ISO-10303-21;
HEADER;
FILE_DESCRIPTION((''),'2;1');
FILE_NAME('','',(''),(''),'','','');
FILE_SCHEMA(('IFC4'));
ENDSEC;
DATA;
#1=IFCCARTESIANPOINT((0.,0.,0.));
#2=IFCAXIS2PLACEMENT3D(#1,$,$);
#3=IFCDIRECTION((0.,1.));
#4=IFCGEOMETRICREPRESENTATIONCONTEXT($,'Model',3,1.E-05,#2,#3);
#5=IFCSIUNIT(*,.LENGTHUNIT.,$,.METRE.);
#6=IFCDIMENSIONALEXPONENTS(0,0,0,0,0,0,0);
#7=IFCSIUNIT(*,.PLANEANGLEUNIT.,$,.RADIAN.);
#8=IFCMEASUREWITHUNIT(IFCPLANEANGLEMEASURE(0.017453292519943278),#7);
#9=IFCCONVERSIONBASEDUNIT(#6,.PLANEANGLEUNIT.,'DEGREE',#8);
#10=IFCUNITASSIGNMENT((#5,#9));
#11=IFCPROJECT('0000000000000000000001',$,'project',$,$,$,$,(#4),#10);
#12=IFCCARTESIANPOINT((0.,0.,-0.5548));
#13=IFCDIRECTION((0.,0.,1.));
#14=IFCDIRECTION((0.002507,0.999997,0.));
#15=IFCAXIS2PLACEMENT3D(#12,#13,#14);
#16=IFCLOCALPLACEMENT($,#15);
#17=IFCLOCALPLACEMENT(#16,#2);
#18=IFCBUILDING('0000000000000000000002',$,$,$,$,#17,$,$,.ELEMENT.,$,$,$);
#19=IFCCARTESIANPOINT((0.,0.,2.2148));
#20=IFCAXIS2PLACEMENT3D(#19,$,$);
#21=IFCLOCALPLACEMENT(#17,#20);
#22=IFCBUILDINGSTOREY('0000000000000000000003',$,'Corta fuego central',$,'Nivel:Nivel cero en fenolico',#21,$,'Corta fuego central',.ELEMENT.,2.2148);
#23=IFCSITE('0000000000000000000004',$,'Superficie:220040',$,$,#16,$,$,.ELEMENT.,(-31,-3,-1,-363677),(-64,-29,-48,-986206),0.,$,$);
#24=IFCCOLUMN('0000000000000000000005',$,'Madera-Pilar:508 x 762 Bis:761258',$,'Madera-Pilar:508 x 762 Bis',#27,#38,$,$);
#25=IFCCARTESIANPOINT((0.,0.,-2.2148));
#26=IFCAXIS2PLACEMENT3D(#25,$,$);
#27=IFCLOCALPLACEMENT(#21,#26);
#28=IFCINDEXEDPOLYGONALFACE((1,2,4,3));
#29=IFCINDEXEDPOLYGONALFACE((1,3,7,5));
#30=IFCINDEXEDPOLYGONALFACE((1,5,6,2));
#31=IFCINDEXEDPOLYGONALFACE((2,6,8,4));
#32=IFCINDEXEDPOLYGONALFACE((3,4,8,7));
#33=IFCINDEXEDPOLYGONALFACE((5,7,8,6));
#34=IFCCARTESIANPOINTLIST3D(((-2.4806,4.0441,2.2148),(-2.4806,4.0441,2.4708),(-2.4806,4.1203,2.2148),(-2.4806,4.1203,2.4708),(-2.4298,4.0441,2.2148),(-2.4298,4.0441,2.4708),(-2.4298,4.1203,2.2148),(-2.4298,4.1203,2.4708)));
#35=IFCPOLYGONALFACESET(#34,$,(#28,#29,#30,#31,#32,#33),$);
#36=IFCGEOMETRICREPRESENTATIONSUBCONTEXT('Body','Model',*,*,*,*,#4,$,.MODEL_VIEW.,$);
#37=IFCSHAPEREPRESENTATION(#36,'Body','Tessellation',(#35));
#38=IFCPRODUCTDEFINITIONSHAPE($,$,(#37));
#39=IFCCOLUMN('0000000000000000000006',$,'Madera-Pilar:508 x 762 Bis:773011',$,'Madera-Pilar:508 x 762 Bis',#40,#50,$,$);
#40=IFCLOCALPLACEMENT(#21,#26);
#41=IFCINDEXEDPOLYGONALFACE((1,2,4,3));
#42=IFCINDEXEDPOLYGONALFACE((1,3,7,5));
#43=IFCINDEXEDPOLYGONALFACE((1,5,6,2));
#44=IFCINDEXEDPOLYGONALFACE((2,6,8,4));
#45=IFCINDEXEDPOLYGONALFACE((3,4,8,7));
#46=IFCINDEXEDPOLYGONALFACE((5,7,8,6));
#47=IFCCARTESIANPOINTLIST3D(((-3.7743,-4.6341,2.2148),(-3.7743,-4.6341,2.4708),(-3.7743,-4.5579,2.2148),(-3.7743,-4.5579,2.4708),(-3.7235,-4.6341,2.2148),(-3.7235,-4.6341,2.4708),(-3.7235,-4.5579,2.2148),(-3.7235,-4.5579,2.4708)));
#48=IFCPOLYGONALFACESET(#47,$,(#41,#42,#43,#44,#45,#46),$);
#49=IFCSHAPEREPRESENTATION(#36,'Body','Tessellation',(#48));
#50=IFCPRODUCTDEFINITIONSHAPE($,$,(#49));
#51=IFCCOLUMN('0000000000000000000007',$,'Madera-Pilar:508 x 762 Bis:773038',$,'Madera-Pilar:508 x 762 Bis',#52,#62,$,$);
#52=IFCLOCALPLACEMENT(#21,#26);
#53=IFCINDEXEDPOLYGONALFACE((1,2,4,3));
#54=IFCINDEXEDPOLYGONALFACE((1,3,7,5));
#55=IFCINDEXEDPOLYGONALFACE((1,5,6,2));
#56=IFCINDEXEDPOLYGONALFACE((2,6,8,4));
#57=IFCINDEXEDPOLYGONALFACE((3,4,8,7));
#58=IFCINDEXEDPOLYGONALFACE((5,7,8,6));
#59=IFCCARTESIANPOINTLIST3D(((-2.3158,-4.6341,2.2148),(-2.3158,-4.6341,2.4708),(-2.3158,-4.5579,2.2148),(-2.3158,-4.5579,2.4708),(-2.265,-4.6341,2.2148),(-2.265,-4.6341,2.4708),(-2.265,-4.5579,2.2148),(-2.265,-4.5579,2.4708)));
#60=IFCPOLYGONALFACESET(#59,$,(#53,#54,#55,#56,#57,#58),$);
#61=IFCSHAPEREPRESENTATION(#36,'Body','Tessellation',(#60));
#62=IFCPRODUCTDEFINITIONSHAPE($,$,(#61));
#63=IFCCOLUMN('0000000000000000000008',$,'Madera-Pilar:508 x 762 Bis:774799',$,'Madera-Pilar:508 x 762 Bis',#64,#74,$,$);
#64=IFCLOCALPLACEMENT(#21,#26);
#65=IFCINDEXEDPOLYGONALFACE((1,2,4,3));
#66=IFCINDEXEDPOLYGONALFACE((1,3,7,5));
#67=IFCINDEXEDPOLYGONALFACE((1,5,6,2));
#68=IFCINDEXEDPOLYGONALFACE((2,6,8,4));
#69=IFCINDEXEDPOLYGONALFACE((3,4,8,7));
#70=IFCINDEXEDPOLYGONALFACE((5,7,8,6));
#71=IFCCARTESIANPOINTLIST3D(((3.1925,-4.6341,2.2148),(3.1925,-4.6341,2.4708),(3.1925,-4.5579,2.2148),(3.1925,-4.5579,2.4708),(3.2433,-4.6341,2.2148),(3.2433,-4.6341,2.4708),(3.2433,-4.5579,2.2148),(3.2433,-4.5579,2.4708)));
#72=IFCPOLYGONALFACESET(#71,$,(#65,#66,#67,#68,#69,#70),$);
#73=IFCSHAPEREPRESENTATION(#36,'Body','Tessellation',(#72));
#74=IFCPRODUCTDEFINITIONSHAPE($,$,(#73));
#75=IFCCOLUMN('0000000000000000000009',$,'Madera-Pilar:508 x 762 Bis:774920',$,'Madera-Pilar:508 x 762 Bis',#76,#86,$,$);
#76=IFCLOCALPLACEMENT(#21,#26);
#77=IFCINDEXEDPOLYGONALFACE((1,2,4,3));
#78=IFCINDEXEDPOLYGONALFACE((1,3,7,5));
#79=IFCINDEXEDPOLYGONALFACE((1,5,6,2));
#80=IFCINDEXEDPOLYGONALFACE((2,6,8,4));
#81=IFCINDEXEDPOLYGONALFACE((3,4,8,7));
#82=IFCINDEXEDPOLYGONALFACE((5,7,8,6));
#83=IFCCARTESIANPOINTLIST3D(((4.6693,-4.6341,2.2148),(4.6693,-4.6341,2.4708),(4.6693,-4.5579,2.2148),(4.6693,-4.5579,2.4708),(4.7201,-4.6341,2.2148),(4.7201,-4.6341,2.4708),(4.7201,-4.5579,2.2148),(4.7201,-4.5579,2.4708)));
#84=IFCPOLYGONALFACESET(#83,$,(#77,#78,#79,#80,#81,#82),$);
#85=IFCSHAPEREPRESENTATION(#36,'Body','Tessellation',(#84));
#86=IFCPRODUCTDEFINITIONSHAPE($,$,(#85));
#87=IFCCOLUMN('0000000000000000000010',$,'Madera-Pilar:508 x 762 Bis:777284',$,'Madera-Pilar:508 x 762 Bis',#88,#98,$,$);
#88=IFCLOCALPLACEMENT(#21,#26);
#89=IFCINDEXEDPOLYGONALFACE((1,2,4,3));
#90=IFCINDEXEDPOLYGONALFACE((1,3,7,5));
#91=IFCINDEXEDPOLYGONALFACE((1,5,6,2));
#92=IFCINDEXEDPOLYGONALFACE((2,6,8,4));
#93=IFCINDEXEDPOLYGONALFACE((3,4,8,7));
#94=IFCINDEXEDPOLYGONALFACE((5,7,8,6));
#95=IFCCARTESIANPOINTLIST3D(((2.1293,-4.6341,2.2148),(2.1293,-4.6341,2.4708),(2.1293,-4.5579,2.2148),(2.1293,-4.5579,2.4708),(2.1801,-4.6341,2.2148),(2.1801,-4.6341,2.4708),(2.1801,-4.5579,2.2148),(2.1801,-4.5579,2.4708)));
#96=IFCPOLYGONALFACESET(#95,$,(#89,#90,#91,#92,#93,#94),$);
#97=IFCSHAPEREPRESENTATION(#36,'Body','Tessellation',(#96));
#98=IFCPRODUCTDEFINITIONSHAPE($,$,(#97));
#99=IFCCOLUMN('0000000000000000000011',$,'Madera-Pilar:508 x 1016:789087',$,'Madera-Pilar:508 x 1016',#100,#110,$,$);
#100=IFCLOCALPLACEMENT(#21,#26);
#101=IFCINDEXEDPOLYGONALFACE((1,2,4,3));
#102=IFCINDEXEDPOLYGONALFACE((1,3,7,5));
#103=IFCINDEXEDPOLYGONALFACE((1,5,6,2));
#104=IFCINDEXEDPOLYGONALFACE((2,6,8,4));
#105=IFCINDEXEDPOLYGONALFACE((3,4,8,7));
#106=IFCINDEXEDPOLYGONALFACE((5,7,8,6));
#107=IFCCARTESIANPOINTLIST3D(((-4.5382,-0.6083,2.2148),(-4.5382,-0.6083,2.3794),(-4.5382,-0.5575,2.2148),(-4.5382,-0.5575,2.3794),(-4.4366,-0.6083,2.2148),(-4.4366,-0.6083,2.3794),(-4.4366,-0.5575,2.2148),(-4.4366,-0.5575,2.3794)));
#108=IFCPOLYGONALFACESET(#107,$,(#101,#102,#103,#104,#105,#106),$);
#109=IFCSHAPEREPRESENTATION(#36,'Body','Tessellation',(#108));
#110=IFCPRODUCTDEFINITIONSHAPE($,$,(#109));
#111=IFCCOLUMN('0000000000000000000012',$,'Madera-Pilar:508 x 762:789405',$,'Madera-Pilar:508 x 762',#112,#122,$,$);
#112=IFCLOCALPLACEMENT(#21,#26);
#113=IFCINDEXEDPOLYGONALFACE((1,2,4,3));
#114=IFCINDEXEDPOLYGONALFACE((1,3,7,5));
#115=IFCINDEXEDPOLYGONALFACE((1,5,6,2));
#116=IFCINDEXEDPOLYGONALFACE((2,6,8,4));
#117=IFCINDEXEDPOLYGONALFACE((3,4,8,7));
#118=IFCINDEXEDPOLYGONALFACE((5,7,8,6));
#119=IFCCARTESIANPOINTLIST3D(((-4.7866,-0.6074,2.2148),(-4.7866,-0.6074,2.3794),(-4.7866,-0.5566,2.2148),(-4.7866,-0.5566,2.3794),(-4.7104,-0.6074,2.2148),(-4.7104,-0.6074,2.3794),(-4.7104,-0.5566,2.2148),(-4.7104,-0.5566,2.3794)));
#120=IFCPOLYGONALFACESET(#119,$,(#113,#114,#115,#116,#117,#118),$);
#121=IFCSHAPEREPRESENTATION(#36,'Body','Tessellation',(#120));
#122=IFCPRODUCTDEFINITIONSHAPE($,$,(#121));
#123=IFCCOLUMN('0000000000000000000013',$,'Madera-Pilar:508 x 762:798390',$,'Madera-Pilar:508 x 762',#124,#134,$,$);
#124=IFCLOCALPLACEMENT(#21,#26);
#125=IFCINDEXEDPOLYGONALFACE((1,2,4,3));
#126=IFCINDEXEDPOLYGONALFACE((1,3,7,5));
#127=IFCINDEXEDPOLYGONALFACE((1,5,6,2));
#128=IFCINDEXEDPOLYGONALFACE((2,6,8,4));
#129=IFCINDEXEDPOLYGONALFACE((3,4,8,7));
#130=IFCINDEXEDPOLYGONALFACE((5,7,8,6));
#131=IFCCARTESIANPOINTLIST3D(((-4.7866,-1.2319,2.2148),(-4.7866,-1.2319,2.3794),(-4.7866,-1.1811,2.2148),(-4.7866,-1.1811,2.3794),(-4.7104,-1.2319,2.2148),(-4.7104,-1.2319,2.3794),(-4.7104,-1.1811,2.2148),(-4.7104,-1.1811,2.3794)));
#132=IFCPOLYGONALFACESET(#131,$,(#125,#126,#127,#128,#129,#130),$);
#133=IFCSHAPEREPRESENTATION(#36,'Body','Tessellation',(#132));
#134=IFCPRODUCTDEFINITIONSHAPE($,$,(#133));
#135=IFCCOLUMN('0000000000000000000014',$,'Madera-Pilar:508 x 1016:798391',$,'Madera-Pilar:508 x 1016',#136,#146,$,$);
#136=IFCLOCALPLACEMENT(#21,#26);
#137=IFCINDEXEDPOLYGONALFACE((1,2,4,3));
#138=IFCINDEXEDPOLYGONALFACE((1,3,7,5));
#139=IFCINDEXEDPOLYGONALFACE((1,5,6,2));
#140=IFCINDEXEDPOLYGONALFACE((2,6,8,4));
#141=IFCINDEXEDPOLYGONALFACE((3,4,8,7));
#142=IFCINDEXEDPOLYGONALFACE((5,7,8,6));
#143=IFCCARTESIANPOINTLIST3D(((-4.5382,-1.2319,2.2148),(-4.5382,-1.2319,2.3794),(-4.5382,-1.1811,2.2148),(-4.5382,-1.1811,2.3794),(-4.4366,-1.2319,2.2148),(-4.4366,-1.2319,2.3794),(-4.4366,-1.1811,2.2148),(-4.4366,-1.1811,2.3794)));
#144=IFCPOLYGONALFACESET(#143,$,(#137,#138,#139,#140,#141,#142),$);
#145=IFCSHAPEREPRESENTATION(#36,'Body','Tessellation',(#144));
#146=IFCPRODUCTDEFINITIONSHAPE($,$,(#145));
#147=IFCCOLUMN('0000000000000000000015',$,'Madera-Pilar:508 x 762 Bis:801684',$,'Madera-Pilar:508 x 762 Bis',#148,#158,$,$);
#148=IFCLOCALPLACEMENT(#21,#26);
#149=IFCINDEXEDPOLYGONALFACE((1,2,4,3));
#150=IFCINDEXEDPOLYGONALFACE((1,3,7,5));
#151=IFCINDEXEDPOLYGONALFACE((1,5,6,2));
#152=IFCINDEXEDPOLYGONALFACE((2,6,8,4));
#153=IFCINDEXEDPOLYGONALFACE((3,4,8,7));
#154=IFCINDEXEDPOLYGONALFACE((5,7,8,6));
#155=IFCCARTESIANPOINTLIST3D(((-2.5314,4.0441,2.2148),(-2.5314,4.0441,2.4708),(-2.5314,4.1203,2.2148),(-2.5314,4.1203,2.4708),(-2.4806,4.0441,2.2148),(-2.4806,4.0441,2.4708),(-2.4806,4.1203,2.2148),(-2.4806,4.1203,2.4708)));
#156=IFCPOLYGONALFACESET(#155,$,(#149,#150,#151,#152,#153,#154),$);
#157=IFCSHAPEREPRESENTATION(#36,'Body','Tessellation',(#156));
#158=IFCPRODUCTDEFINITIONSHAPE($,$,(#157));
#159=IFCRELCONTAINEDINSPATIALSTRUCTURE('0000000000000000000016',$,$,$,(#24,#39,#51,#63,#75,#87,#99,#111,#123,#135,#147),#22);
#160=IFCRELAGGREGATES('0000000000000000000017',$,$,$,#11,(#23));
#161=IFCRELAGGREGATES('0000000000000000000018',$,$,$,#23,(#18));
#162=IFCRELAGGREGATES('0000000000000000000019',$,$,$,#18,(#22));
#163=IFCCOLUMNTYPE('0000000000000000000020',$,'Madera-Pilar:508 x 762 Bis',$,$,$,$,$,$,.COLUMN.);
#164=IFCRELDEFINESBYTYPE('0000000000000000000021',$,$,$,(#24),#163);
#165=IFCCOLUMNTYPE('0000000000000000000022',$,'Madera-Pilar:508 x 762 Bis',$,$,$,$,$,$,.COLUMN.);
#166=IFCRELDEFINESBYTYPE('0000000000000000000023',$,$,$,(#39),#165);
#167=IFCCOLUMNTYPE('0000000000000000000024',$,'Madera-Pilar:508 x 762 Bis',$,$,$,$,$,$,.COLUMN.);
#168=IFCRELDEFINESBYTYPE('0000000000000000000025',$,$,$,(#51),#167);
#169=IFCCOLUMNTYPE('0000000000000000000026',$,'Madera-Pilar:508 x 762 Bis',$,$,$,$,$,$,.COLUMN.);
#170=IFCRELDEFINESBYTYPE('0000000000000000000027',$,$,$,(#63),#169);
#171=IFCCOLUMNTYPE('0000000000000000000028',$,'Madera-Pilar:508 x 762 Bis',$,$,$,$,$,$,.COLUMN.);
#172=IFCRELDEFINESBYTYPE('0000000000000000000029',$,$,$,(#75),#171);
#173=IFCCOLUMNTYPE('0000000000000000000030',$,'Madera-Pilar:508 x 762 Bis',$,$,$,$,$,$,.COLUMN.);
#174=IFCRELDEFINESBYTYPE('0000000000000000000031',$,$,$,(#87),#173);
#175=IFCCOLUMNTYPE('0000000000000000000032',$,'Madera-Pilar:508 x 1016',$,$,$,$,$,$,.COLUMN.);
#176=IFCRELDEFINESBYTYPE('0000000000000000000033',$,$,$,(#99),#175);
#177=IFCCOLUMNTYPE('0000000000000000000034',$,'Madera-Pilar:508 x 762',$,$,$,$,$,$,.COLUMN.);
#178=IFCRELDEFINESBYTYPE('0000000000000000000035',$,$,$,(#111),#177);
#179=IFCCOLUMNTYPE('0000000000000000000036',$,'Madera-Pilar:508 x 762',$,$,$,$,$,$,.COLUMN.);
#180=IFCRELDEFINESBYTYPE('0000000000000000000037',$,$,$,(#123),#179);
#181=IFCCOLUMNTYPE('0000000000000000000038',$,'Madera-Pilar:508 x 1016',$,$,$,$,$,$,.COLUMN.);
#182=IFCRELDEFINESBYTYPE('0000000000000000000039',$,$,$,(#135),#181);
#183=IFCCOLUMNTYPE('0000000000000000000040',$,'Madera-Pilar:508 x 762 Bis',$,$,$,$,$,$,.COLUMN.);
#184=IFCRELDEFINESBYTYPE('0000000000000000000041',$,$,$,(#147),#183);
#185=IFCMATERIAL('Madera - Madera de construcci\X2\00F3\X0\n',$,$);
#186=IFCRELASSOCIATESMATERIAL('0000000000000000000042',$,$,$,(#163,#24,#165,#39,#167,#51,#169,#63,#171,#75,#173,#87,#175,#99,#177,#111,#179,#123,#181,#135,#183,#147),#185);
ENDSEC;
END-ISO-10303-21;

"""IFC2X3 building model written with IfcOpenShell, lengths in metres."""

from ifc_helpers import new_model, entity, si_unit, converted_unit, direction, frame, frame_2d, origin, place, context, subcontext, project, spatial, rectangle, extrude, source, transform, mapped, material, type_object, type_shapes, element, save


model = new_model("IFC2X3")

# Units and contexts
model_context = context("Model", 3, precision=1e-05, world=origin(), true_north=direction((0.0, 1.0)))
body_context = subcontext(model_context, "Body", "Model", "MODEL_VIEW")
ifc_project = project(units=[si_unit("LENGTHUNIT", "METRE"), converted_unit("PLANEANGLEUNIT", "DEGREE", entity("IfcPlaneAngleMeasure", 0.017453292519943278), si_unit("PLANEANGLEUNIT", "RADIAN"), dimensions=[0, 0, 0, 0, 0, 0, 0])], contexts=[model_context])

# Site, building, storey
site_placement = place(None, frame((0.0, 0.0, -0.5548), z_axis=(0.0, 0.0, 1.0), x_axis=(0.002507, 0.999997, 0.0)))
site = spatial("IfcSite", under=ifc_project, at=site_placement, Name="Superficie:220040", CompositionType="ELEMENT", RefLatitude=(-31, -3, -1, -363677), RefLongitude=(-64, -29, -48, -986206), RefElevation=0.0)
building_placement = place(site_placement, origin())
building = spatial("IfcBuilding", under=site, at=building_placement, CompositionType="ELEMENT")
storey_placement = place(building_placement, frame((0.0, 0.0, 2.2148)))
storey = spatial("IfcBuildingStorey", under=building, at=storey_placement, Name="Corta fuego central", ObjectType="Nivel:Nivel cero en fenolico", LongName="Corta fuego central", CompositionType="ELEMENT", Elevation=2.2148)

# Columns
ifc_material = material(Name="Madera - Madera de construcción")
column_type_1 = type_object("IfcColumnType", Name="Madera-Pilar:508 x 762 Bis", PredefinedType="COLUMN", material=ifc_material)
shared_shape_1 = source(origin(), body_context, "Body", "SweptSolid", [
    extrude(rectangle(XDim=0.0508, YDim=0.0762, at=frame_2d((0.0, 0.0), x_axis=(1.0, 0.0))), frame((-2.4552, 4.0822, 2.2148), z_axis=(0.0, 0.0, 1.0), x_axis=(-1.0, 0.0, 0.0)), (0.0, 0.0, 1.0), 0.256),
])
type_shapes(column_type_1, [shared_shape_1])
column_1_placement = place(storey_placement, frame((0.0, 0.0, -2.2148)))
element("IfcColumn", 1, at=column_1_placement, inside=storey, type_object=column_type_1, material=ifc_material, Name="Madera-Pilar:508 x 762 Bis:761258", ObjectType="Madera-Pilar:508 x 762 Bis", context=body_context, shape_type="MappedRepresentation", body=[
    mapped(shared_shape_1, transform((0.0, 0.0, 0.0), scale=1.0)),
])
column_type_2 = type_object("IfcColumnType", Name="Madera-Pilar:508 x 762 Bis", PredefinedType="COLUMN", material=ifc_material)
shared_shape_2 = source(origin(), body_context, "Body", "SweptSolid", [
    extrude(rectangle(XDim=0.0508, YDim=0.0762, at=frame_2d((0.0, 0.0), x_axis=(1.0, 0.0))), frame((-3.7489, -4.596, 2.2148)), (0.0, 0.0, 1.0), 0.256),
])
type_shapes(column_type_2, [shared_shape_2])
column_2_placement = place(storey_placement, frame((0.0, 0.0, -2.2148)))
element("IfcColumn", 2, at=column_2_placement, inside=storey, type_object=column_type_2, material=ifc_material, Name="Madera-Pilar:508 x 762 Bis:773011", ObjectType="Madera-Pilar:508 x 762 Bis", context=body_context, shape_type="MappedRepresentation", body=[
    mapped(shared_shape_2, transform((0.0, 0.0, 0.0), scale=1.0)),
])
column_type_3 = type_object("IfcColumnType", Name="Madera-Pilar:508 x 762 Bis", PredefinedType="COLUMN", material=ifc_material)
shared_shape_3 = source(origin(), body_context, "Body", "SweptSolid", [
    extrude(rectangle(XDim=0.0508, YDim=0.0762, at=frame_2d((0.0, 0.0), x_axis=(1.0, 0.0))), frame((-2.2904, -4.596, 2.2148)), (0.0, 0.0, 1.0), 0.256),
])
type_shapes(column_type_3, [shared_shape_3])
column_3_placement = place(storey_placement, frame((0.0, 0.0, -2.2148)))
element("IfcColumn", 3, at=column_3_placement, inside=storey, type_object=column_type_3, material=ifc_material, Name="Madera-Pilar:508 x 762 Bis:773038", ObjectType="Madera-Pilar:508 x 762 Bis", context=body_context, shape_type="MappedRepresentation", body=[
    mapped(shared_shape_3, transform((0.0, 0.0, 0.0), scale=1.0)),
])
column_type_4 = type_object("IfcColumnType", Name="Madera-Pilar:508 x 762 Bis", PredefinedType="COLUMN", material=ifc_material)
shared_shape_4 = source(origin(), body_context, "Body", "SweptSolid", [
    extrude(rectangle(XDim=0.0508, YDim=0.0762, at=frame_2d((0.0, 0.0), x_axis=(1.0, 0.0))), frame((3.2179, -4.596, 2.2148)), (0.0, 0.0, 1.0), 0.256),
])
type_shapes(column_type_4, [shared_shape_4])
column_4_placement = place(storey_placement, frame((0.0, 0.0, -2.2148)))
element("IfcColumn", 4, at=column_4_placement, inside=storey, type_object=column_type_4, material=ifc_material, Name="Madera-Pilar:508 x 762 Bis:774799", ObjectType="Madera-Pilar:508 x 762 Bis", context=body_context, shape_type="MappedRepresentation", body=[
    mapped(shared_shape_4, transform((0.0, 0.0, 0.0), scale=1.0)),
])
column_type_5 = type_object("IfcColumnType", Name="Madera-Pilar:508 x 762 Bis", PredefinedType="COLUMN", material=ifc_material)
shared_shape_5 = source(origin(), body_context, "Body", "SweptSolid", [
    extrude(rectangle(XDim=0.0508, YDim=0.0762, at=frame_2d((0.0, 0.0), x_axis=(1.0, 0.0))), frame((4.6947, -4.596, 2.2148)), (0.0, 0.0, 1.0), 0.256),
])
type_shapes(column_type_5, [shared_shape_5])
column_5_placement = place(storey_placement, frame((0.0, 0.0, -2.2148)))
element("IfcColumn", 5, at=column_5_placement, inside=storey, type_object=column_type_5, material=ifc_material, Name="Madera-Pilar:508 x 762 Bis:774920", ObjectType="Madera-Pilar:508 x 762 Bis", context=body_context, shape_type="MappedRepresentation", body=[
    mapped(shared_shape_5, transform((0.0, 0.0, 0.0), scale=1.0)),
])
column_type_6 = type_object("IfcColumnType", Name="Madera-Pilar:508 x 762 Bis", PredefinedType="COLUMN", material=ifc_material)
shared_shape_6 = source(origin(), body_context, "Body", "SweptSolid", [
    extrude(rectangle(XDim=0.0508, YDim=0.0762, at=frame_2d((0.0, 0.0), x_axis=(1.0, 0.0))), frame((2.1547, -4.596, 2.2148)), (0.0, 0.0, 1.0), 0.256),
])
type_shapes(column_type_6, [shared_shape_6])
column_6_placement = place(storey_placement, frame((0.0, 0.0, -2.2148)))
element("IfcColumn", 6, at=column_6_placement, inside=storey, type_object=column_type_6, material=ifc_material, Name="Madera-Pilar:508 x 762 Bis:777284", ObjectType="Madera-Pilar:508 x 762 Bis", context=body_context, shape_type="MappedRepresentation", body=[
    mapped(shared_shape_6, transform((0.0, 0.0, 0.0), scale=1.0)),
])
column_type_7 = type_object("IfcColumnType", Name="Madera-Pilar:508 x 1016", PredefinedType="COLUMN", material=ifc_material)
shared_shape_7 = source(origin(), body_context, "Body", "SweptSolid", [
    extrude(rectangle(XDim=0.1016, YDim=0.0508, at=frame_2d((0.0, 0.0), x_axis=(1.0, 0.0))), frame((-4.4874, -0.5829, 2.2148), z_axis=(0.0, 0.0, 1.0), x_axis=(-1.0, 0.0, 0.0)), (0.0, 0.0, 1.0), 0.1646),
])
type_shapes(column_type_7, [shared_shape_7])
column_7_placement = place(storey_placement, frame((0.0, 0.0, -2.2148)))
element("IfcColumn", 7, at=column_7_placement, inside=storey, type_object=column_type_7, material=ifc_material, Name="Madera-Pilar:508 x 1016:789087", ObjectType="Madera-Pilar:508 x 1016", context=body_context, shape_type="MappedRepresentation", body=[
    mapped(shared_shape_7, transform((0.0, 0.0, 0.0), scale=1.0)),
])
column_type_8 = type_object("IfcColumnType", Name="Madera-Pilar:508 x 762", PredefinedType="COLUMN", material=ifc_material)
shared_shape_8 = source(origin(), body_context, "Body", "SweptSolid", [
    extrude(rectangle(XDim=0.0762, YDim=0.0508, at=frame_2d((0.0, 0.0), x_axis=(1.0, 0.0))), frame((-4.7485, -0.582, 2.2148), z_axis=(0.0, 0.0, 1.0), x_axis=(-1.0, 0.0, 0.0)), (0.0, 0.0, 1.0), 0.1646),
])
type_shapes(column_type_8, [shared_shape_8])
column_8_placement = place(storey_placement, frame((0.0, 0.0, -2.2148)))
element("IfcColumn", 8, at=column_8_placement, inside=storey, type_object=column_type_8, material=ifc_material, Name="Madera-Pilar:508 x 762:789405", ObjectType="Madera-Pilar:508 x 762", context=body_context, shape_type="MappedRepresentation", body=[
    mapped(shared_shape_8, transform((0.0, 0.0, 0.0), scale=1.0)),
])
column_type_9 = type_object("IfcColumnType", Name="Madera-Pilar:508 x 762", PredefinedType="COLUMN", material=ifc_material)
shared_shape_9 = source(origin(), body_context, "Body", "SweptSolid", [
    extrude(rectangle(XDim=0.0762, YDim=0.0508, at=frame_2d((0.0, 0.0), x_axis=(1.0, 0.0))), frame((-4.7485, -1.2065, 2.2148), z_axis=(0.0, 0.0, 1.0), x_axis=(-1.0, 0.0, 0.0)), (0.0, 0.0, 1.0), 0.1646),
])
type_shapes(column_type_9, [shared_shape_9])
column_9_placement = place(storey_placement, frame((0.0, 0.0, -2.2148)))
element("IfcColumn", 9, at=column_9_placement, inside=storey, type_object=column_type_9, material=ifc_material, Name="Madera-Pilar:508 x 762:798390", ObjectType="Madera-Pilar:508 x 762", context=body_context, shape_type="MappedRepresentation", body=[
    mapped(shared_shape_9, transform((0.0, 0.0, 0.0), scale=1.0)),
])
column_type_10 = type_object("IfcColumnType", Name="Madera-Pilar:508 x 1016", PredefinedType="COLUMN", material=ifc_material)
shared_shape_10 = source(origin(), body_context, "Body", "SweptSolid", [
    extrude(rectangle(XDim=0.1016, YDim=0.0508, at=frame_2d((0.0, 0.0), x_axis=(1.0, 0.0))), frame((-4.4874, -1.2065, 2.2148), z_axis=(0.0, 0.0, 1.0), x_axis=(-1.0, 0.0, 0.0)), (0.0, 0.0, 1.0), 0.1646),
])
type_shapes(column_type_10, [shared_shape_10])
column_10_placement = place(storey_placement, frame((0.0, 0.0, -2.2148)))
element("IfcColumn", 10, at=column_10_placement, inside=storey, type_object=column_type_10, material=ifc_material, Name="Madera-Pilar:508 x 1016:798391", ObjectType="Madera-Pilar:508 x 1016", context=body_context, shape_type="MappedRepresentation", body=[
    mapped(shared_shape_10, transform((0.0, 0.0, 0.0), scale=1.0)),
])
column_type_11 = type_object("IfcColumnType", Name="Madera-Pilar:508 x 762 Bis", PredefinedType="COLUMN", material=ifc_material)
shared_shape_11 = source(origin(), body_context, "Body", "SweptSolid", [
    extrude(rectangle(XDim=0.0508, YDim=0.0762, at=frame_2d((0.0, 0.0), x_axis=(1.0, 0.0))), frame((-2.506, 4.0822, 2.2148), z_axis=(0.0, 0.0, 1.0), x_axis=(-1.0, 0.0, 0.0)), (0.0, 0.0, 1.0), 0.256),
])
type_shapes(column_type_11, [shared_shape_11])
column_11_placement = place(storey_placement, frame((0.0, 0.0, -2.2148)))
element("IfcColumn", 11, at=column_11_placement, inside=storey, type_object=column_type_11, material=ifc_material, Name="Madera-Pilar:508 x 762 Bis:801684", ObjectType="Madera-Pilar:508 x 762 Bis", context=body_context, shape_type="MappedRepresentation", body=[
    mapped(shared_shape_11, transform((0.0, 0.0, 0.0), scale=1.0)),
])

save(model, "model.ifc")
